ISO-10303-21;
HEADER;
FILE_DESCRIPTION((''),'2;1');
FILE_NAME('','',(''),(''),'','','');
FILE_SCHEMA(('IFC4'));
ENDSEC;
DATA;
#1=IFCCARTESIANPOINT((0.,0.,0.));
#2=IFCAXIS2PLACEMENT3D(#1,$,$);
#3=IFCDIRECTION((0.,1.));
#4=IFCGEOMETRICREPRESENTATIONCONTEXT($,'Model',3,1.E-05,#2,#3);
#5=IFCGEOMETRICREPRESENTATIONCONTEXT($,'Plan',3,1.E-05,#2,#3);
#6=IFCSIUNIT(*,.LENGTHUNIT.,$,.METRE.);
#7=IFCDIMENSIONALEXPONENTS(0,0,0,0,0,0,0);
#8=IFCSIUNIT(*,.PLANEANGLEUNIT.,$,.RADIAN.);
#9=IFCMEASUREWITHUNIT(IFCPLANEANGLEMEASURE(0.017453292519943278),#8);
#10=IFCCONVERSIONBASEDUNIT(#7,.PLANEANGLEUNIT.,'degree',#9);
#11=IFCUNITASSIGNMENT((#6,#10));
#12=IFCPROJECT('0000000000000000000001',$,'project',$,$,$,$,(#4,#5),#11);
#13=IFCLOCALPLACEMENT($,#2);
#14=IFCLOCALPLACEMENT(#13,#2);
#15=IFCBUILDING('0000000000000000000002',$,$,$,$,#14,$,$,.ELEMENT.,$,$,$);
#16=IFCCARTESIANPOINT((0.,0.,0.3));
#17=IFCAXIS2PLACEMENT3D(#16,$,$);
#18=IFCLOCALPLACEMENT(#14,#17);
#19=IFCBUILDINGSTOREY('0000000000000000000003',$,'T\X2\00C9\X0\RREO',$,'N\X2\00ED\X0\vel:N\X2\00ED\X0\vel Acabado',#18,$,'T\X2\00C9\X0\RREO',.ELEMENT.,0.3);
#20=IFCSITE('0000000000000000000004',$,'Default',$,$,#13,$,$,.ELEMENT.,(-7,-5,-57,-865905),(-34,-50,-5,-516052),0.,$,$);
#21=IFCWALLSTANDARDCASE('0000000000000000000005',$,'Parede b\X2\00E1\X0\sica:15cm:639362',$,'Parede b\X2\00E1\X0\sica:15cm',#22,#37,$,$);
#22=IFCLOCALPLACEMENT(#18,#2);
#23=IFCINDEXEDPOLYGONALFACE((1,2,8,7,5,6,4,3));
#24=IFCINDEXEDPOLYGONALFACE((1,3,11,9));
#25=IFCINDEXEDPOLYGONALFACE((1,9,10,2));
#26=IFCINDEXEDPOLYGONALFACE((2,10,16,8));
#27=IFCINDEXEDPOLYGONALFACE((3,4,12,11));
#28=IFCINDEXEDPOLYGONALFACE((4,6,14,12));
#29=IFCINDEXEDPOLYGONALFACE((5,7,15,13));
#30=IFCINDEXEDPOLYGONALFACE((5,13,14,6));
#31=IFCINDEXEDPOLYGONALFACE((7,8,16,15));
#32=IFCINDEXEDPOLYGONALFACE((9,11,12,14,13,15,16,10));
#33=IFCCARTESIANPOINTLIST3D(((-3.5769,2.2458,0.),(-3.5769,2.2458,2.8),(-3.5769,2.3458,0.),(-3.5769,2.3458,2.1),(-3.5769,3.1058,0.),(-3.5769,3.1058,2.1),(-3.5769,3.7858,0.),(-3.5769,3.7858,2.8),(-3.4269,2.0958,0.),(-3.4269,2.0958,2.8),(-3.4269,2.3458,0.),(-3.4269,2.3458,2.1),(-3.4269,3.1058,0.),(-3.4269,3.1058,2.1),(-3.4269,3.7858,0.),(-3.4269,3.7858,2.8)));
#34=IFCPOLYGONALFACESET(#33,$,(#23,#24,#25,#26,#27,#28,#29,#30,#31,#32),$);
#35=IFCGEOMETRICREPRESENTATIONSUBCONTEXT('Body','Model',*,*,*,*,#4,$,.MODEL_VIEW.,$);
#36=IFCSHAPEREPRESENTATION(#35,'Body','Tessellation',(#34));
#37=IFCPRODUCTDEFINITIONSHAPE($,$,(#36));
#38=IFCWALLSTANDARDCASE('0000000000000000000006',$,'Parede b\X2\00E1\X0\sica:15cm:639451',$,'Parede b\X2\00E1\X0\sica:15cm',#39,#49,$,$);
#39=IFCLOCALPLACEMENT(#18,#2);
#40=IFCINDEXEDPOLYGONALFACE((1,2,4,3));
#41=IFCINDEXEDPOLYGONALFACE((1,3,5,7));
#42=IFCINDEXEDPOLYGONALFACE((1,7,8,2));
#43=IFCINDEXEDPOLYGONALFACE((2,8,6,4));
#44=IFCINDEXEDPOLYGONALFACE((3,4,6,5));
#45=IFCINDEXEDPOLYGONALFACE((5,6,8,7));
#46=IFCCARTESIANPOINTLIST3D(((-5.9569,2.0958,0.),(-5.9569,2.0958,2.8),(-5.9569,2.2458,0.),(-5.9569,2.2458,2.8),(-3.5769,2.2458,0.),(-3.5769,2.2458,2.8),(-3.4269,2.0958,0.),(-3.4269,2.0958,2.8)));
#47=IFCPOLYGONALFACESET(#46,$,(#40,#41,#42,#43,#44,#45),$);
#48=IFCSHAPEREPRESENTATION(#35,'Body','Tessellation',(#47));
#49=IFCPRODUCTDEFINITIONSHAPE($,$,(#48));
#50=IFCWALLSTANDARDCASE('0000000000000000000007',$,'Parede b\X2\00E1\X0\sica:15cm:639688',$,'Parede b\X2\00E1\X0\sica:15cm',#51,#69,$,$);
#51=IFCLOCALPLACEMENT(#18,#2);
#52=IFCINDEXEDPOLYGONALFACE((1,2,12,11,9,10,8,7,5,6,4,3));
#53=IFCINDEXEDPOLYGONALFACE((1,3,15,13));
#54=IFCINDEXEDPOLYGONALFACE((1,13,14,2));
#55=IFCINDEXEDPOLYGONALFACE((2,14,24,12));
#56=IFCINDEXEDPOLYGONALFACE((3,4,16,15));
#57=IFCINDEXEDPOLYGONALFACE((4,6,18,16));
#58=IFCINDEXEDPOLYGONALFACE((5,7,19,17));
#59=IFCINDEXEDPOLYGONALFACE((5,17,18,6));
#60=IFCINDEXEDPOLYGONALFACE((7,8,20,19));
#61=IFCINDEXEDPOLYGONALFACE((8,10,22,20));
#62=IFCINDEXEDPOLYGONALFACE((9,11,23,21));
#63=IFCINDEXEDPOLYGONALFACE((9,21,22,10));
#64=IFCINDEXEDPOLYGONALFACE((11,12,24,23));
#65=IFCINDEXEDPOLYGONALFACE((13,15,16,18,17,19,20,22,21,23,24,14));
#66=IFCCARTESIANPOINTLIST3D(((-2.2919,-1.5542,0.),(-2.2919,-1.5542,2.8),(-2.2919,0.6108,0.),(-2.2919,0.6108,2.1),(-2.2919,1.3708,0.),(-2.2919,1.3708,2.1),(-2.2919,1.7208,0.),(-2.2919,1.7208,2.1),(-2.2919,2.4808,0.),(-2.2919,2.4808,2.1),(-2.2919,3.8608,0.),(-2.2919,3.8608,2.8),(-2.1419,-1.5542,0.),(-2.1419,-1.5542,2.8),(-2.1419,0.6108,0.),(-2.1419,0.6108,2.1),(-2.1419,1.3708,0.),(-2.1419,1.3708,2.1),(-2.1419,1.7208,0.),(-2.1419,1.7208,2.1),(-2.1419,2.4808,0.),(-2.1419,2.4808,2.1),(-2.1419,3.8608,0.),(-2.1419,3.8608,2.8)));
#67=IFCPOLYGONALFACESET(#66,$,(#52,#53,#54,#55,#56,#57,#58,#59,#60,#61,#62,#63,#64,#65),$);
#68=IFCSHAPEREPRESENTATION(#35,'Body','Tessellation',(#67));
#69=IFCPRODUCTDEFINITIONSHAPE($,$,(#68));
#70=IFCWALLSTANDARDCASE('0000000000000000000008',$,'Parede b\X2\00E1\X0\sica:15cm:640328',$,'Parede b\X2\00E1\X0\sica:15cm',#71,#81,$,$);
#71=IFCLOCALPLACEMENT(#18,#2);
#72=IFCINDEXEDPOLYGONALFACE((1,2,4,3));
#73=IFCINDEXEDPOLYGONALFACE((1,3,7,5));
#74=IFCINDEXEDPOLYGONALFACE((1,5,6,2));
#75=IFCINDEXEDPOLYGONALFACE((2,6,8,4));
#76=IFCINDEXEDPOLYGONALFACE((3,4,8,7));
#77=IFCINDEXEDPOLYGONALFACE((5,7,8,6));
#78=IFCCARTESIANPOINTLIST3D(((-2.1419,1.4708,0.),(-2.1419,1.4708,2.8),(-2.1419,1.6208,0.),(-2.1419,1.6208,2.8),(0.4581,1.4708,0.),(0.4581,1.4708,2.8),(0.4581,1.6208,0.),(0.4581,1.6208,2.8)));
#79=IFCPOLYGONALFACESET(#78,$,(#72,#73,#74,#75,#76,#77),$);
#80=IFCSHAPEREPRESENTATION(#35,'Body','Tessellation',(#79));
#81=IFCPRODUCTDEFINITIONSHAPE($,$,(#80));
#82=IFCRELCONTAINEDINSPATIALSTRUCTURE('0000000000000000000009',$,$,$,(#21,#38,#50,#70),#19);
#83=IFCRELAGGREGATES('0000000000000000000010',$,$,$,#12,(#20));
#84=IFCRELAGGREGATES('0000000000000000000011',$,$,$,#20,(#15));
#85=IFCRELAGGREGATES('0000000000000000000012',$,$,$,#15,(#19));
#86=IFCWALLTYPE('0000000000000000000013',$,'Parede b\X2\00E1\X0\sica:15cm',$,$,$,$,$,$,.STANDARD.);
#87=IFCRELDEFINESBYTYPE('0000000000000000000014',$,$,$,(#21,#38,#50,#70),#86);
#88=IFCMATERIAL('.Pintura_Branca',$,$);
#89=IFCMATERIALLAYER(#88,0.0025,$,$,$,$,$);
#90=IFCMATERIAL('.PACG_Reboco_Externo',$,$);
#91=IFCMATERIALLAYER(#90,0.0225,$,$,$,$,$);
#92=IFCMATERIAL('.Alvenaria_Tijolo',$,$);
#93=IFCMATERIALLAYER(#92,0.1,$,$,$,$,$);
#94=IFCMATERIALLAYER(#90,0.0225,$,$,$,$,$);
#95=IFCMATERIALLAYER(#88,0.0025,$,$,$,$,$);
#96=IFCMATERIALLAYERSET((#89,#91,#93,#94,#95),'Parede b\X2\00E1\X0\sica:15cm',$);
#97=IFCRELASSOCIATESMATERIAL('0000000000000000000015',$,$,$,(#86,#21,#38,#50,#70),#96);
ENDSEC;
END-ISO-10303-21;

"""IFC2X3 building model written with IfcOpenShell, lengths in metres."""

from ifc_helpers import new_model, entity, si_unit, converted_unit, direction, frame, frame_2d, origin, place, context, subcontext, project, spatial, polyline, rectangle, outline, extrude, material, layer, layer_set, layer_usage, type_object, element, save


model = new_model("IFC2X3")

# Units and contexts
model_context = context("Model", 3, precision=1e-05, world=origin(), true_north=direction((0.0, 1.0)))
plan_context = context("Plan", 3, precision=1e-05, world=origin(), true_north=direction((0.0, 1.0)))
body_context = subcontext(model_context, "Body", "Model", "MODEL_VIEW")
ifc_project = project(units=[si_unit("LENGTHUNIT", "METRE"), converted_unit("PLANEANGLEUNIT", "degree", entity("IfcPlaneAngleMeasure", 0.017453292519943278), si_unit("PLANEANGLEUNIT", "RADIAN"), dimensions=[0, 0, 0, 0, 0, 0, 0])], contexts=[model_context, plan_context])

# Site, building, storey
site_placement = place(None, origin())
site = spatial("IfcSite", under=ifc_project, at=site_placement, Name="Default", CompositionType="ELEMENT", RefLatitude=(-7, -5, -57, -865905), RefLongitude=(-34, -50, -5, -516052), RefElevation=0.0)
building_placement = place(site_placement, origin())
building = spatial("IfcBuilding", under=site, at=building_placement, CompositionType="ELEMENT")
storey_placement = place(building_placement, frame((0.0, 0.0, 0.3)))
storey = spatial("IfcBuildingStorey", under=building, at=storey_placement, Name="TÉRREO", ObjectType="Nível:Nível Acabado", LongName="TÉRREO", CompositionType="ELEMENT", Elevation=0.3)

# Shared definitions
ifc_material_1 = material(Name=".Pintura_Branca")
ifc_layer_1 = layer(ifc_material_1, 0.0025)
ifc_material_2 = material(Name=".PACG_Reboco_Externo")
ifc_layer_2 = layer(ifc_material_2, 0.0225)
ifc_material_3 = material(Name=".Alvenaria_Tijolo")
ifc_layer_3 = layer(ifc_material_3, 0.1)
ifc_layer_4 = layer(ifc_material_2, 0.0225)
ifc_layer_5 = layer(ifc_material_1, 0.0025)
ifc_layer_set_1 = layer_set([ifc_layer_1, ifc_layer_2, ifc_layer_3, ifc_layer_4, ifc_layer_5], Name="Parede básica:15cm")
wall_type = type_object("IfcWallType", Name="Parede básica:15cm", PredefinedType="STANDARD", material=ifc_layer_set_1)

# Wall, opening
ifc_layer_usage_1 = layer_usage(ifc_layer_set_1, "AXIS2", "NEGATIVE", 0.075)
wall_1_placement = place(storey_placement, frame((-3.5019, 3.7858, 0.0), z_axis=(0.0, 0.0, 1.0), x_axis=(0.0, -1.0, 0.0)))
wall_1 = element("IfcWallStandardCase", 1, at=wall_1_placement, inside=storey, type_object=wall_type, material=ifc_layer_usage_1, Name="Parede básica:15cm:639362", ObjectType="Parede básica:15cm", context=body_context, shape_type="SweptSolid", body=[
    extrude(outline(polyline([(0.0, -0.075), (1.54, -0.075), (1.69, 0.075), (0.0, 0.075), (0.0, -0.075)])), origin(), (0.0, 0.0, 1.0), 2.8),
])
opening_1_placement = place(wall_1_placement, frame((1.44, 0.075, 0.0)))
element("IfcOpeningElement", 2, at=opening_1_placement, cuts=wall_1, ObjectType="Opening", context=body_context, shape_type="SweptSolid", body=[
    extrude(rectangle(XDim=0.76, YDim=2.1, at=frame_2d((1.05, 0.38), x_axis=(0.0, -1.0))), frame((0.0, 0.0, 0.0), z_axis=(0.0, -1.0, 0.0), x_axis=(0.0, 0.0, 1.0)), (0.0, 0.0, 1.0), 0.15),
])

# Wall
ifc_layer_usage_2 = layer_usage(ifc_layer_set_1, "AXIS2", "NEGATIVE", 0.075)
wall_2_placement = place(storey_placement, frame((-3.4269, 2.1708, 0.0), z_axis=(0.0, 0.0, 1.0), x_axis=(-1.0, 0.0, 0.0)))
element("IfcWallStandardCase", 3, at=wall_2_placement, inside=storey, type_object=wall_type, material=ifc_layer_usage_2, Name="Parede básica:15cm:639451", ObjectType="Parede básica:15cm", context=body_context, shape_type="SweptSolid", body=[
    extrude(outline(polyline([(2.53, -0.075), (2.53, 0.075), (0.0, 0.075), (0.15, -0.075), (2.53, -0.075)])), origin(), (0.0, 0.0, 1.0), 2.8),
])

# Wall, openings
ifc_layer_usage_3 = layer_usage(ifc_layer_set_1, "AXIS2", "NEGATIVE", 0.075)
wall_3_placement = place(storey_placement, frame((-2.2169, 3.8608, 0.0), z_axis=(0.0, 0.0, 1.0), x_axis=(0.0, -1.0, 0.0)))
wall_3 = element("IfcWallStandardCase", 4, at=wall_3_placement, inside=storey, type_object=wall_type, material=ifc_layer_usage_3, Name="Parede básica:15cm:639688", ObjectType="Parede básica:15cm", context=body_context, shape_type="SweptSolid", body=[
    extrude(rectangle(XDim=5.415, YDim=0.15, at=frame_2d((2.7075, 0.0), x_axis=(1.0, 0.0))), origin(), (0.0, 0.0, 1.0), 2.8),
])
opening_2_placement = place(wall_3_placement, frame((1.38, -0.075, 0.0)))
element("IfcOpeningElement", 5, at=opening_2_placement, cuts=wall_3, ObjectType="Opening", context=body_context, shape_type="SweptSolid", body=[
    extrude(rectangle(XDim=0.76, YDim=2.1, at=frame_2d((1.05, 0.38), x_axis=(0.0, 1.0))), frame((0.0, 0.0, 0.0), z_axis=(0.0, 1.0, 0.0), x_axis=(0.0, 0.0, 1.0)), (0.0, 0.0, 1.0), 0.15),
])
opening_3_placement = place(wall_3_placement, frame((2.49, -0.075, 0.0)))
element("IfcOpeningElement", 6, at=opening_3_placement, cuts=wall_3, ObjectType="Opening", context=body_context, shape_type="SweptSolid", body=[
    extrude(rectangle(XDim=0.76, YDim=2.1, at=frame_2d((1.05, 0.38), x_axis=(0.0, -1.0))), frame((0.0, 0.0, 0.0), z_axis=(0.0, 1.0, 0.0), x_axis=(0.0, 0.0, 1.0)), (0.0, 0.0, 1.0), 0.15),
])

# Wall
ifc_layer_usage_4 = layer_usage(ifc_layer_set_1, "AXIS2", "NEGATIVE", 0.075)
wall_4_placement = place(storey_placement, frame((0.4581, 1.5458, 0.0), z_axis=(0.0, 0.0, 1.0), x_axis=(-1.0, 0.0, 0.0)))
element("IfcWallStandardCase", 7, at=wall_4_placement, inside=storey, type_object=wall_type, material=ifc_layer_usage_4, Name="Parede básica:15cm:640328", ObjectType="Parede básica:15cm", context=body_context, shape_type="SweptSolid", body=[
    extrude(rectangle(XDim=2.6, YDim=0.15, at=frame_2d((1.3, 0.0), x_axis=(-1.0, 0.0))), origin(), (0.0, 0.0, 1.0), 2.8),
])

save(model, "model.ifc")
